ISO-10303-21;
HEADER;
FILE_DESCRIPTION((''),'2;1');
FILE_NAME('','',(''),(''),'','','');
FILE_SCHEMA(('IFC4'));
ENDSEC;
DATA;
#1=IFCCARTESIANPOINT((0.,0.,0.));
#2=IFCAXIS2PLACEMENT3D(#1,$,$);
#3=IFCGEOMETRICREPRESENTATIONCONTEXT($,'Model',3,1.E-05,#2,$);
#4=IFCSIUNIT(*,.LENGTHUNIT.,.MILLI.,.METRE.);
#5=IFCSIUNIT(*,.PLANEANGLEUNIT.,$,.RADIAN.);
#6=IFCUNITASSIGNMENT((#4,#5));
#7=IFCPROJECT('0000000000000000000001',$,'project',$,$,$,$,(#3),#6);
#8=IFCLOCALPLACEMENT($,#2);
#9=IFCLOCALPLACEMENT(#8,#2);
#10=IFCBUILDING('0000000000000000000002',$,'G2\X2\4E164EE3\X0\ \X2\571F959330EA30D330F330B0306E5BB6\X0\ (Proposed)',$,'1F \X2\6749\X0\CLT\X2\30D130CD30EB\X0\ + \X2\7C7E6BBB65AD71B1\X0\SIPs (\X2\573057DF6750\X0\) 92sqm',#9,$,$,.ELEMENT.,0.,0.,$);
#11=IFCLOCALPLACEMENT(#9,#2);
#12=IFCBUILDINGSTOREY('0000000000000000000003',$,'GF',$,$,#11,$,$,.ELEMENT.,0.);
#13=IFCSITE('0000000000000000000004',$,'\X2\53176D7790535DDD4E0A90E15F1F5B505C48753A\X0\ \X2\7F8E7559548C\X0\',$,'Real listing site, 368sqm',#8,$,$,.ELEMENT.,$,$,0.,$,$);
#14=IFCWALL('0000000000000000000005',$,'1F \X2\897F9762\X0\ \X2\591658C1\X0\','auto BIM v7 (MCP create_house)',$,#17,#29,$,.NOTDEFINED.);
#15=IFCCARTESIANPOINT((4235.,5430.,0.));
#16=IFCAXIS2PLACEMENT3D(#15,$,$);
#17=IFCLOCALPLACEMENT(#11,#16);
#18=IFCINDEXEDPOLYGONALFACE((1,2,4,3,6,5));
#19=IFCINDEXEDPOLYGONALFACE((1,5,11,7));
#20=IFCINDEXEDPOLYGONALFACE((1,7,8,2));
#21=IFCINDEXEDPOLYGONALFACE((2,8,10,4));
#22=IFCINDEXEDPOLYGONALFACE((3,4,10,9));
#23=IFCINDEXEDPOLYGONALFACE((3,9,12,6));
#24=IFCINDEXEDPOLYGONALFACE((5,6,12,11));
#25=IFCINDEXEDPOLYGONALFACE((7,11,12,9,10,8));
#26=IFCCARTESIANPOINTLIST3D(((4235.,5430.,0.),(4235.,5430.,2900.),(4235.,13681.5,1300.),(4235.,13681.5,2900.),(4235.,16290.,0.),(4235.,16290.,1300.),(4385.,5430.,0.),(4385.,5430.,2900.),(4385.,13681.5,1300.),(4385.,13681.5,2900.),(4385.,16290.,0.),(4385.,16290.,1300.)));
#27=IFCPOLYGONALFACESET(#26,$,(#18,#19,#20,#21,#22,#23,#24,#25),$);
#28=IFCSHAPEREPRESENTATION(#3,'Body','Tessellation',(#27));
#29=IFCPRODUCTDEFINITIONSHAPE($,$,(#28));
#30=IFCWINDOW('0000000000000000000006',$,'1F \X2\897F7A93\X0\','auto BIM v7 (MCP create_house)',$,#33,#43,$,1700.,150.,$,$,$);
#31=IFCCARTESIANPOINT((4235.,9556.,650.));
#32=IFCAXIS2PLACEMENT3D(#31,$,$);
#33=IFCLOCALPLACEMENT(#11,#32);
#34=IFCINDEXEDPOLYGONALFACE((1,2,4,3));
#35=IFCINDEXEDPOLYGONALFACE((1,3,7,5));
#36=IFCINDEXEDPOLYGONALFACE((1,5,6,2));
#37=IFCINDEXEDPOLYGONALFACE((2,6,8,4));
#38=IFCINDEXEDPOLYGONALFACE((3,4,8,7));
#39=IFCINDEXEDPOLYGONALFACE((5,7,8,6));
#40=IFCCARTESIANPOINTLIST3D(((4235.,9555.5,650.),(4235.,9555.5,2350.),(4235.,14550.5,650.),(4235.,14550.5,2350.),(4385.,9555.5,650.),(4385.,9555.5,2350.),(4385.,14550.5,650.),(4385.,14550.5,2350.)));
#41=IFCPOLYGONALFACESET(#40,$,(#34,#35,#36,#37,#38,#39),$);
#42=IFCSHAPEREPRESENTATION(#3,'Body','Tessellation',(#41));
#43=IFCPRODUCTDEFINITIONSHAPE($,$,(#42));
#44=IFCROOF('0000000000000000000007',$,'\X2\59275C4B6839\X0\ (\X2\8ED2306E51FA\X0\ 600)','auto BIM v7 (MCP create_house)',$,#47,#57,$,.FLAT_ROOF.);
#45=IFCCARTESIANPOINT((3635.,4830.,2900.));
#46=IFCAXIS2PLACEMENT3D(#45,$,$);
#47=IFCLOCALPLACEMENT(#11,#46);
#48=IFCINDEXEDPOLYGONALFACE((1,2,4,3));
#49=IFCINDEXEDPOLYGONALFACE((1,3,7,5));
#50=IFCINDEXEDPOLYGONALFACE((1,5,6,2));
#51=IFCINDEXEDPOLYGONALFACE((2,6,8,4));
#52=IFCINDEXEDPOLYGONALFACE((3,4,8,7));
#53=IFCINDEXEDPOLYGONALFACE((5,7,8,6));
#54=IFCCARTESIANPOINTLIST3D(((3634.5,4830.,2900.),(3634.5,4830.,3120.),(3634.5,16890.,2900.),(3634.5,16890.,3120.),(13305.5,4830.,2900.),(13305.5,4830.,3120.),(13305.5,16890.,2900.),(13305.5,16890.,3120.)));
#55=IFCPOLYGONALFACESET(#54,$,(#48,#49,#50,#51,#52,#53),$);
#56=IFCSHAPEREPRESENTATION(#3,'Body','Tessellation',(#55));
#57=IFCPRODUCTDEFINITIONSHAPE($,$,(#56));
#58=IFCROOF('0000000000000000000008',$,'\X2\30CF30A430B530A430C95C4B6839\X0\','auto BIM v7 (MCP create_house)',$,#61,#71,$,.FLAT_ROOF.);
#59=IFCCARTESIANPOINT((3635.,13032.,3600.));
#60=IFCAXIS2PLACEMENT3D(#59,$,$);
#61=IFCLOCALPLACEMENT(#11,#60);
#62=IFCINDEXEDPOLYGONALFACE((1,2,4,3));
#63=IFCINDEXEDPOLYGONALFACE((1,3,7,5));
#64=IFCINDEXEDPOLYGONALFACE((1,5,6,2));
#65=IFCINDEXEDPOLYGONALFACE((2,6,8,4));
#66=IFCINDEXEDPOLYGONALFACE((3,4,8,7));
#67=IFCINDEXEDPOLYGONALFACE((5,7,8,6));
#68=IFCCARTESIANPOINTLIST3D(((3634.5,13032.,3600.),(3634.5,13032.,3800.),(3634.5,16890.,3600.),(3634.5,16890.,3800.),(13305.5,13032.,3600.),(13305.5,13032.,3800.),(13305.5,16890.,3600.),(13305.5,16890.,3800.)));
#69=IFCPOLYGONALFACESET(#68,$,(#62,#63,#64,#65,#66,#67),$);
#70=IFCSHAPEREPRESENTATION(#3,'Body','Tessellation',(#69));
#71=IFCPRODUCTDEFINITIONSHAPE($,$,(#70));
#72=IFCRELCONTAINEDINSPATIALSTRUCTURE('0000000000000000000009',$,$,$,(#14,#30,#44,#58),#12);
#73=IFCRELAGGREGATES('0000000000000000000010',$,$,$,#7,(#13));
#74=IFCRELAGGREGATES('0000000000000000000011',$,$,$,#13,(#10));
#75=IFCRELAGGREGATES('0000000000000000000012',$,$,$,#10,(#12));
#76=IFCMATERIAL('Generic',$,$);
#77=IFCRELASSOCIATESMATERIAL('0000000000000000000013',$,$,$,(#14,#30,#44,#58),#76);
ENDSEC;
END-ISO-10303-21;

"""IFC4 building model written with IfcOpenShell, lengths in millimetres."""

from ifc_helpers import new_model, si_unit, frame, frame_2d, origin, place, context, project, spatial, rectangle, extrude, material, element, fill, save


model = new_model("IFC4")

# Units and contexts
model_context = context("Model", 3, precision=1e-05, world=origin())
ifc_project = project(units=[si_unit("LENGTHUNIT", "METRE", prefix="MILLI"), si_unit("PLANEANGLEUNIT", "RADIAN")], contexts=[model_context])

# Site, building, storey
site_placement = place(None, origin())
site = spatial("IfcSite", under=ifc_project, at=site_placement, Name="北海道川上郡弟子屈町 美留和", ObjectType="Real listing site, 368sqm", CompositionType="ELEMENT", RefElevation=0.0)
building_placement = place(site_placement, origin())
building = spatial("IfcBuilding", under=site, at=building_placement, Name="G2世代 土間リビングの家 (Proposed)", ObjectType="1F 杉CLTパネル + 籾殻断熱SIPs (地域材) 92sqm", CompositionType="ELEMENT", ElevationOfRefHeight=0.0, ElevationOfTerrain=0.0)
storey_placement = place(building_placement, origin())
storey = spatial("IfcBuildingStorey", under=building, at=storey_placement, Name="GF", CompositionType="ELEMENT", Elevation=0.0)

# Shared definitions
ifc_material = material(Name="Generic")

# Wall, opening, window
wall_1_placement = place(storey_placement, frame((4235.0, 5430.0, 0.0)))
wall_1 = element("IfcWall", 1, at=wall_1_placement, inside=storey, material=ifc_material, Name="1F 西面 外壁", Description="auto BIM v7 (MCP create_house)", PredefinedType="NOTDEFINED", context=model_context, shape_type="SweptSolid", body=[
    extrude(rectangle(XDim=150.0, YDim=10860.0, at=frame_2d((75.0, 5430.0))), frame((4235.0, 5430.0, 0.0)), (0.0, 0.0, 1.0), 2900.0),
])
opening_1_placement = place(storey_placement, frame((4235.0, 9556.0, 650.0)))
opening_1 = element("IfcOpeningElement", 2, at=opening_1_placement, cuts=wall_1, PredefinedType="NOTDEFINED", context=model_context, shape_type="SweptSolid", body=[
    extrude(rectangle(XDim=150.0, YDim=4995.0, at=frame_2d((75.0, 2497.0))), frame((4235.0, 9556.0, 650.0)), (0.0, 0.0, 1.0), 1700.0),
])
window_1_placement = place(storey_placement, frame((4235.0, 9556.0, 650.0)))
window_1 = element("IfcWindow", 3, at=window_1_placement, inside=storey, material=ifc_material, Name="1F 西窓", Description="auto BIM v7 (MCP create_house)", OverallHeight=1700.0, OverallWidth=150.0, context=model_context, shape_type="SweptSolid", body=[
    extrude(rectangle(XDim=150.0, YDim=4995.0, at=frame_2d((75.0, 2497.0))), frame((4235.0, 9556.0, 650.0)), (0.0, 0.0, 1.0), 1700.0),
])
fill(opening_1, window_1)

# Roofs
roof_1_placement = place(storey_placement, frame((3635.0, 4830.0, 2900.0)))
element("IfcRoof", 4, at=roof_1_placement, inside=storey, material=ifc_material, Name="大屋根 (軒の出 600)", Description="auto BIM v7 (MCP create_house)", PredefinedType="FLAT_ROOF", context=model_context, shape_type="SweptSolid", body=[
    extrude(rectangle(XDim=9671.0, YDim=12060.0, at=frame_2d((4835.0, 6030.0))), frame((3635.0, 4830.0, 2900.0)), (0.0, 0.0, 1.0), 220.0),
])
roof_2_placement = place(storey_placement, frame((3635.0, 13032.0, 3600.0)))
element("IfcRoof", 5, at=roof_2_placement, inside=storey, material=ifc_material, Name="ハイサイド屋根", Description="auto BIM v7 (MCP create_house)", PredefinedType="FLAT_ROOF", context=model_context, shape_type="SweptSolid", body=[
    extrude(rectangle(XDim=9671.0, YDim=3858.0, at=frame_2d((4835.0, 1929.0))), frame((3635.0, 13032.0, 3600.0)), (0.0, 0.0, 1.0), 200.0),
])

save(model, "model.ifc")
